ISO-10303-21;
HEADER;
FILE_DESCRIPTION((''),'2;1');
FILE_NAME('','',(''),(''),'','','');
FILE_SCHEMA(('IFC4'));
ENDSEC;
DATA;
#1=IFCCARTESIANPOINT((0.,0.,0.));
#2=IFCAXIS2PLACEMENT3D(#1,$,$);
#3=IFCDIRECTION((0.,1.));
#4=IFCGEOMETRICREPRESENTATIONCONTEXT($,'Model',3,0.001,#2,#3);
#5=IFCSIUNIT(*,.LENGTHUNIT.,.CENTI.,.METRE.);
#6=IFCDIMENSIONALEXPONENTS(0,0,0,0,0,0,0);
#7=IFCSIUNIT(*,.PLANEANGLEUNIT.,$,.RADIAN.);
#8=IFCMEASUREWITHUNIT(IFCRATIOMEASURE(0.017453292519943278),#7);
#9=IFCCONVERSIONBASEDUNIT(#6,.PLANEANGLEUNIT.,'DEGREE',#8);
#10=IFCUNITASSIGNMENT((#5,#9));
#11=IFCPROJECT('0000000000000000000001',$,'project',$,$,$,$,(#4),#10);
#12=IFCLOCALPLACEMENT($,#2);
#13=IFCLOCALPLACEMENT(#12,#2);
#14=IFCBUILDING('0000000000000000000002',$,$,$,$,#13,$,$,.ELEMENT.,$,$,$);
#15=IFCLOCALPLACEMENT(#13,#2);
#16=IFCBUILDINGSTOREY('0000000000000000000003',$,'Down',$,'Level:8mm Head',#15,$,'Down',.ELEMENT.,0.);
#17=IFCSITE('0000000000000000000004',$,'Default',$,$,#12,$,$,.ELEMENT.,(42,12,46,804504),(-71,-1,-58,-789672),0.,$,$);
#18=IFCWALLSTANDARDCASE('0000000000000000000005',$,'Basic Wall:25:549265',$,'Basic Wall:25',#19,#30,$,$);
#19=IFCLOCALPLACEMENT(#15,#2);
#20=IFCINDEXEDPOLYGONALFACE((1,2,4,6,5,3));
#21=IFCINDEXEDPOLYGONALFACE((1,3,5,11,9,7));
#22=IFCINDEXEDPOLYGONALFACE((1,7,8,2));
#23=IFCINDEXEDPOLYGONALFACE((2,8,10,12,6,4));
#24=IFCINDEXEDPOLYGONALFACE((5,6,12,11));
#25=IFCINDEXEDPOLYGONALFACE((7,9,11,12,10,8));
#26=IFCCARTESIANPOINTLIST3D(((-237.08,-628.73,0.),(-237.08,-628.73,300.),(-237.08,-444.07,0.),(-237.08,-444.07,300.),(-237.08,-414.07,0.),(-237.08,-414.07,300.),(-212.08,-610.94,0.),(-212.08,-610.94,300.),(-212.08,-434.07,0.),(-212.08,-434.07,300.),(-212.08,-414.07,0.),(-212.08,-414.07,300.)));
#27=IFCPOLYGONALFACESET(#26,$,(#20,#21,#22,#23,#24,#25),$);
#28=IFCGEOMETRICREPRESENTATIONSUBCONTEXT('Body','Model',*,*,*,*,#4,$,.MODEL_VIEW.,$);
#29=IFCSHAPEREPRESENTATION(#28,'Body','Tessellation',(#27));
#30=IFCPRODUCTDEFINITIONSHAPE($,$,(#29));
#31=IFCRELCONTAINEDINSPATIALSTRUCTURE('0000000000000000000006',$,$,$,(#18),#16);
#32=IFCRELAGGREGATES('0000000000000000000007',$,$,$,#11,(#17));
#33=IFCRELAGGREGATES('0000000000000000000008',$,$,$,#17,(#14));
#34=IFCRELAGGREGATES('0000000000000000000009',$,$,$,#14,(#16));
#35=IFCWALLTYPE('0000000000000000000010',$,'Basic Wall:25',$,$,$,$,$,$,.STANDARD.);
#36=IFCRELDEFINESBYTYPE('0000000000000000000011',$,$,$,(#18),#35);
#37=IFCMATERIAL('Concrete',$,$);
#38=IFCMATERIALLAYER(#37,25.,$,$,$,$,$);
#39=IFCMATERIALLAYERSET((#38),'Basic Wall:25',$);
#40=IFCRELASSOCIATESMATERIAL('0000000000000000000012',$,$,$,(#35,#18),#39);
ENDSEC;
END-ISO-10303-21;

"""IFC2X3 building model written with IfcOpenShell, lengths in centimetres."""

from ifc_helpers import new_model, entity, si_unit, converted_unit, direction, frame, origin, place, context, subcontext, project, spatial, polyline, outline, extrude, material, layer, layer_set, layer_usage, type_object, element, save


model = new_model("IFC2X3")

# Units and contexts
model_context = context("Model", 3, precision=0.001, world=origin(), true_north=direction((0.0, 1.0)))
body_context = subcontext(model_context, "Body", "Model", "MODEL_VIEW")
ifc_project = project(units=[si_unit("LENGTHUNIT", "METRE", prefix="CENTI"), converted_unit("PLANEANGLEUNIT", "DEGREE", entity("IfcRatioMeasure", 0.017453292519943278), si_unit("PLANEANGLEUNIT", "RADIAN"), dimensions=[0, 0, 0, 0, 0, 0, 0])], contexts=[model_context])

# Site, building, storey
site_placement = place(None, origin())
site = spatial("IfcSite", under=ifc_project, at=site_placement, Name="Default", CompositionType="ELEMENT", RefLatitude=(42, 12, 46, 804504), RefLongitude=(-71, -1, -58, -789672), RefElevation=0.0)
building_placement = place(site_placement, origin())
building = spatial("IfcBuilding", under=site, at=building_placement, CompositionType="ELEMENT")
storey_placement = place(building_placement, origin())
storey = spatial("IfcBuildingStorey", under=building, at=storey_placement, Name="Down", ObjectType="Level:8mm Head", LongName="Down", CompositionType="ELEMENT", Elevation=0.0)

# Wall
ifc_material = material(Name="Concrete")
ifc_layer_1 = layer(ifc_material, 25.0)
ifc_layer_set_1 = layer_set([ifc_layer_1], Name="Basic Wall:25")
wall_type_1 = type_object("IfcWallType", Name="Basic Wall:25", PredefinedType="STANDARD", material=ifc_layer_set_1)
ifc_layer_usage_1 = layer_usage(ifc_layer_set_1, "AXIS2", "NEGATIVE", 12.5)
wall_1_placement = place(storey_placement, frame((-224.58, -628.73, 0.0), z_axis=(0.0, 0.0, 1.0), x_axis=(0.0, 1.0, 0.0)))
element("IfcWallStandardCase", 1, at=wall_1_placement, inside=storey, type_object=wall_type_1, material=ifc_layer_usage_1, Name="Basic Wall:25:549265", ObjectType="Basic Wall:25", context=body_context, shape_type="SweptSolid", body=[
    extrude(outline(polyline([(214.66, -12.5), (214.66, 12.5), (184.66, 12.5), (0.0, 12.5), (17.79, -12.5), (194.66, -12.5), (214.66, -12.5)])), origin(), (0.0, 0.0, 1.0), 300.0),
])

save(model, "model.ifc")
